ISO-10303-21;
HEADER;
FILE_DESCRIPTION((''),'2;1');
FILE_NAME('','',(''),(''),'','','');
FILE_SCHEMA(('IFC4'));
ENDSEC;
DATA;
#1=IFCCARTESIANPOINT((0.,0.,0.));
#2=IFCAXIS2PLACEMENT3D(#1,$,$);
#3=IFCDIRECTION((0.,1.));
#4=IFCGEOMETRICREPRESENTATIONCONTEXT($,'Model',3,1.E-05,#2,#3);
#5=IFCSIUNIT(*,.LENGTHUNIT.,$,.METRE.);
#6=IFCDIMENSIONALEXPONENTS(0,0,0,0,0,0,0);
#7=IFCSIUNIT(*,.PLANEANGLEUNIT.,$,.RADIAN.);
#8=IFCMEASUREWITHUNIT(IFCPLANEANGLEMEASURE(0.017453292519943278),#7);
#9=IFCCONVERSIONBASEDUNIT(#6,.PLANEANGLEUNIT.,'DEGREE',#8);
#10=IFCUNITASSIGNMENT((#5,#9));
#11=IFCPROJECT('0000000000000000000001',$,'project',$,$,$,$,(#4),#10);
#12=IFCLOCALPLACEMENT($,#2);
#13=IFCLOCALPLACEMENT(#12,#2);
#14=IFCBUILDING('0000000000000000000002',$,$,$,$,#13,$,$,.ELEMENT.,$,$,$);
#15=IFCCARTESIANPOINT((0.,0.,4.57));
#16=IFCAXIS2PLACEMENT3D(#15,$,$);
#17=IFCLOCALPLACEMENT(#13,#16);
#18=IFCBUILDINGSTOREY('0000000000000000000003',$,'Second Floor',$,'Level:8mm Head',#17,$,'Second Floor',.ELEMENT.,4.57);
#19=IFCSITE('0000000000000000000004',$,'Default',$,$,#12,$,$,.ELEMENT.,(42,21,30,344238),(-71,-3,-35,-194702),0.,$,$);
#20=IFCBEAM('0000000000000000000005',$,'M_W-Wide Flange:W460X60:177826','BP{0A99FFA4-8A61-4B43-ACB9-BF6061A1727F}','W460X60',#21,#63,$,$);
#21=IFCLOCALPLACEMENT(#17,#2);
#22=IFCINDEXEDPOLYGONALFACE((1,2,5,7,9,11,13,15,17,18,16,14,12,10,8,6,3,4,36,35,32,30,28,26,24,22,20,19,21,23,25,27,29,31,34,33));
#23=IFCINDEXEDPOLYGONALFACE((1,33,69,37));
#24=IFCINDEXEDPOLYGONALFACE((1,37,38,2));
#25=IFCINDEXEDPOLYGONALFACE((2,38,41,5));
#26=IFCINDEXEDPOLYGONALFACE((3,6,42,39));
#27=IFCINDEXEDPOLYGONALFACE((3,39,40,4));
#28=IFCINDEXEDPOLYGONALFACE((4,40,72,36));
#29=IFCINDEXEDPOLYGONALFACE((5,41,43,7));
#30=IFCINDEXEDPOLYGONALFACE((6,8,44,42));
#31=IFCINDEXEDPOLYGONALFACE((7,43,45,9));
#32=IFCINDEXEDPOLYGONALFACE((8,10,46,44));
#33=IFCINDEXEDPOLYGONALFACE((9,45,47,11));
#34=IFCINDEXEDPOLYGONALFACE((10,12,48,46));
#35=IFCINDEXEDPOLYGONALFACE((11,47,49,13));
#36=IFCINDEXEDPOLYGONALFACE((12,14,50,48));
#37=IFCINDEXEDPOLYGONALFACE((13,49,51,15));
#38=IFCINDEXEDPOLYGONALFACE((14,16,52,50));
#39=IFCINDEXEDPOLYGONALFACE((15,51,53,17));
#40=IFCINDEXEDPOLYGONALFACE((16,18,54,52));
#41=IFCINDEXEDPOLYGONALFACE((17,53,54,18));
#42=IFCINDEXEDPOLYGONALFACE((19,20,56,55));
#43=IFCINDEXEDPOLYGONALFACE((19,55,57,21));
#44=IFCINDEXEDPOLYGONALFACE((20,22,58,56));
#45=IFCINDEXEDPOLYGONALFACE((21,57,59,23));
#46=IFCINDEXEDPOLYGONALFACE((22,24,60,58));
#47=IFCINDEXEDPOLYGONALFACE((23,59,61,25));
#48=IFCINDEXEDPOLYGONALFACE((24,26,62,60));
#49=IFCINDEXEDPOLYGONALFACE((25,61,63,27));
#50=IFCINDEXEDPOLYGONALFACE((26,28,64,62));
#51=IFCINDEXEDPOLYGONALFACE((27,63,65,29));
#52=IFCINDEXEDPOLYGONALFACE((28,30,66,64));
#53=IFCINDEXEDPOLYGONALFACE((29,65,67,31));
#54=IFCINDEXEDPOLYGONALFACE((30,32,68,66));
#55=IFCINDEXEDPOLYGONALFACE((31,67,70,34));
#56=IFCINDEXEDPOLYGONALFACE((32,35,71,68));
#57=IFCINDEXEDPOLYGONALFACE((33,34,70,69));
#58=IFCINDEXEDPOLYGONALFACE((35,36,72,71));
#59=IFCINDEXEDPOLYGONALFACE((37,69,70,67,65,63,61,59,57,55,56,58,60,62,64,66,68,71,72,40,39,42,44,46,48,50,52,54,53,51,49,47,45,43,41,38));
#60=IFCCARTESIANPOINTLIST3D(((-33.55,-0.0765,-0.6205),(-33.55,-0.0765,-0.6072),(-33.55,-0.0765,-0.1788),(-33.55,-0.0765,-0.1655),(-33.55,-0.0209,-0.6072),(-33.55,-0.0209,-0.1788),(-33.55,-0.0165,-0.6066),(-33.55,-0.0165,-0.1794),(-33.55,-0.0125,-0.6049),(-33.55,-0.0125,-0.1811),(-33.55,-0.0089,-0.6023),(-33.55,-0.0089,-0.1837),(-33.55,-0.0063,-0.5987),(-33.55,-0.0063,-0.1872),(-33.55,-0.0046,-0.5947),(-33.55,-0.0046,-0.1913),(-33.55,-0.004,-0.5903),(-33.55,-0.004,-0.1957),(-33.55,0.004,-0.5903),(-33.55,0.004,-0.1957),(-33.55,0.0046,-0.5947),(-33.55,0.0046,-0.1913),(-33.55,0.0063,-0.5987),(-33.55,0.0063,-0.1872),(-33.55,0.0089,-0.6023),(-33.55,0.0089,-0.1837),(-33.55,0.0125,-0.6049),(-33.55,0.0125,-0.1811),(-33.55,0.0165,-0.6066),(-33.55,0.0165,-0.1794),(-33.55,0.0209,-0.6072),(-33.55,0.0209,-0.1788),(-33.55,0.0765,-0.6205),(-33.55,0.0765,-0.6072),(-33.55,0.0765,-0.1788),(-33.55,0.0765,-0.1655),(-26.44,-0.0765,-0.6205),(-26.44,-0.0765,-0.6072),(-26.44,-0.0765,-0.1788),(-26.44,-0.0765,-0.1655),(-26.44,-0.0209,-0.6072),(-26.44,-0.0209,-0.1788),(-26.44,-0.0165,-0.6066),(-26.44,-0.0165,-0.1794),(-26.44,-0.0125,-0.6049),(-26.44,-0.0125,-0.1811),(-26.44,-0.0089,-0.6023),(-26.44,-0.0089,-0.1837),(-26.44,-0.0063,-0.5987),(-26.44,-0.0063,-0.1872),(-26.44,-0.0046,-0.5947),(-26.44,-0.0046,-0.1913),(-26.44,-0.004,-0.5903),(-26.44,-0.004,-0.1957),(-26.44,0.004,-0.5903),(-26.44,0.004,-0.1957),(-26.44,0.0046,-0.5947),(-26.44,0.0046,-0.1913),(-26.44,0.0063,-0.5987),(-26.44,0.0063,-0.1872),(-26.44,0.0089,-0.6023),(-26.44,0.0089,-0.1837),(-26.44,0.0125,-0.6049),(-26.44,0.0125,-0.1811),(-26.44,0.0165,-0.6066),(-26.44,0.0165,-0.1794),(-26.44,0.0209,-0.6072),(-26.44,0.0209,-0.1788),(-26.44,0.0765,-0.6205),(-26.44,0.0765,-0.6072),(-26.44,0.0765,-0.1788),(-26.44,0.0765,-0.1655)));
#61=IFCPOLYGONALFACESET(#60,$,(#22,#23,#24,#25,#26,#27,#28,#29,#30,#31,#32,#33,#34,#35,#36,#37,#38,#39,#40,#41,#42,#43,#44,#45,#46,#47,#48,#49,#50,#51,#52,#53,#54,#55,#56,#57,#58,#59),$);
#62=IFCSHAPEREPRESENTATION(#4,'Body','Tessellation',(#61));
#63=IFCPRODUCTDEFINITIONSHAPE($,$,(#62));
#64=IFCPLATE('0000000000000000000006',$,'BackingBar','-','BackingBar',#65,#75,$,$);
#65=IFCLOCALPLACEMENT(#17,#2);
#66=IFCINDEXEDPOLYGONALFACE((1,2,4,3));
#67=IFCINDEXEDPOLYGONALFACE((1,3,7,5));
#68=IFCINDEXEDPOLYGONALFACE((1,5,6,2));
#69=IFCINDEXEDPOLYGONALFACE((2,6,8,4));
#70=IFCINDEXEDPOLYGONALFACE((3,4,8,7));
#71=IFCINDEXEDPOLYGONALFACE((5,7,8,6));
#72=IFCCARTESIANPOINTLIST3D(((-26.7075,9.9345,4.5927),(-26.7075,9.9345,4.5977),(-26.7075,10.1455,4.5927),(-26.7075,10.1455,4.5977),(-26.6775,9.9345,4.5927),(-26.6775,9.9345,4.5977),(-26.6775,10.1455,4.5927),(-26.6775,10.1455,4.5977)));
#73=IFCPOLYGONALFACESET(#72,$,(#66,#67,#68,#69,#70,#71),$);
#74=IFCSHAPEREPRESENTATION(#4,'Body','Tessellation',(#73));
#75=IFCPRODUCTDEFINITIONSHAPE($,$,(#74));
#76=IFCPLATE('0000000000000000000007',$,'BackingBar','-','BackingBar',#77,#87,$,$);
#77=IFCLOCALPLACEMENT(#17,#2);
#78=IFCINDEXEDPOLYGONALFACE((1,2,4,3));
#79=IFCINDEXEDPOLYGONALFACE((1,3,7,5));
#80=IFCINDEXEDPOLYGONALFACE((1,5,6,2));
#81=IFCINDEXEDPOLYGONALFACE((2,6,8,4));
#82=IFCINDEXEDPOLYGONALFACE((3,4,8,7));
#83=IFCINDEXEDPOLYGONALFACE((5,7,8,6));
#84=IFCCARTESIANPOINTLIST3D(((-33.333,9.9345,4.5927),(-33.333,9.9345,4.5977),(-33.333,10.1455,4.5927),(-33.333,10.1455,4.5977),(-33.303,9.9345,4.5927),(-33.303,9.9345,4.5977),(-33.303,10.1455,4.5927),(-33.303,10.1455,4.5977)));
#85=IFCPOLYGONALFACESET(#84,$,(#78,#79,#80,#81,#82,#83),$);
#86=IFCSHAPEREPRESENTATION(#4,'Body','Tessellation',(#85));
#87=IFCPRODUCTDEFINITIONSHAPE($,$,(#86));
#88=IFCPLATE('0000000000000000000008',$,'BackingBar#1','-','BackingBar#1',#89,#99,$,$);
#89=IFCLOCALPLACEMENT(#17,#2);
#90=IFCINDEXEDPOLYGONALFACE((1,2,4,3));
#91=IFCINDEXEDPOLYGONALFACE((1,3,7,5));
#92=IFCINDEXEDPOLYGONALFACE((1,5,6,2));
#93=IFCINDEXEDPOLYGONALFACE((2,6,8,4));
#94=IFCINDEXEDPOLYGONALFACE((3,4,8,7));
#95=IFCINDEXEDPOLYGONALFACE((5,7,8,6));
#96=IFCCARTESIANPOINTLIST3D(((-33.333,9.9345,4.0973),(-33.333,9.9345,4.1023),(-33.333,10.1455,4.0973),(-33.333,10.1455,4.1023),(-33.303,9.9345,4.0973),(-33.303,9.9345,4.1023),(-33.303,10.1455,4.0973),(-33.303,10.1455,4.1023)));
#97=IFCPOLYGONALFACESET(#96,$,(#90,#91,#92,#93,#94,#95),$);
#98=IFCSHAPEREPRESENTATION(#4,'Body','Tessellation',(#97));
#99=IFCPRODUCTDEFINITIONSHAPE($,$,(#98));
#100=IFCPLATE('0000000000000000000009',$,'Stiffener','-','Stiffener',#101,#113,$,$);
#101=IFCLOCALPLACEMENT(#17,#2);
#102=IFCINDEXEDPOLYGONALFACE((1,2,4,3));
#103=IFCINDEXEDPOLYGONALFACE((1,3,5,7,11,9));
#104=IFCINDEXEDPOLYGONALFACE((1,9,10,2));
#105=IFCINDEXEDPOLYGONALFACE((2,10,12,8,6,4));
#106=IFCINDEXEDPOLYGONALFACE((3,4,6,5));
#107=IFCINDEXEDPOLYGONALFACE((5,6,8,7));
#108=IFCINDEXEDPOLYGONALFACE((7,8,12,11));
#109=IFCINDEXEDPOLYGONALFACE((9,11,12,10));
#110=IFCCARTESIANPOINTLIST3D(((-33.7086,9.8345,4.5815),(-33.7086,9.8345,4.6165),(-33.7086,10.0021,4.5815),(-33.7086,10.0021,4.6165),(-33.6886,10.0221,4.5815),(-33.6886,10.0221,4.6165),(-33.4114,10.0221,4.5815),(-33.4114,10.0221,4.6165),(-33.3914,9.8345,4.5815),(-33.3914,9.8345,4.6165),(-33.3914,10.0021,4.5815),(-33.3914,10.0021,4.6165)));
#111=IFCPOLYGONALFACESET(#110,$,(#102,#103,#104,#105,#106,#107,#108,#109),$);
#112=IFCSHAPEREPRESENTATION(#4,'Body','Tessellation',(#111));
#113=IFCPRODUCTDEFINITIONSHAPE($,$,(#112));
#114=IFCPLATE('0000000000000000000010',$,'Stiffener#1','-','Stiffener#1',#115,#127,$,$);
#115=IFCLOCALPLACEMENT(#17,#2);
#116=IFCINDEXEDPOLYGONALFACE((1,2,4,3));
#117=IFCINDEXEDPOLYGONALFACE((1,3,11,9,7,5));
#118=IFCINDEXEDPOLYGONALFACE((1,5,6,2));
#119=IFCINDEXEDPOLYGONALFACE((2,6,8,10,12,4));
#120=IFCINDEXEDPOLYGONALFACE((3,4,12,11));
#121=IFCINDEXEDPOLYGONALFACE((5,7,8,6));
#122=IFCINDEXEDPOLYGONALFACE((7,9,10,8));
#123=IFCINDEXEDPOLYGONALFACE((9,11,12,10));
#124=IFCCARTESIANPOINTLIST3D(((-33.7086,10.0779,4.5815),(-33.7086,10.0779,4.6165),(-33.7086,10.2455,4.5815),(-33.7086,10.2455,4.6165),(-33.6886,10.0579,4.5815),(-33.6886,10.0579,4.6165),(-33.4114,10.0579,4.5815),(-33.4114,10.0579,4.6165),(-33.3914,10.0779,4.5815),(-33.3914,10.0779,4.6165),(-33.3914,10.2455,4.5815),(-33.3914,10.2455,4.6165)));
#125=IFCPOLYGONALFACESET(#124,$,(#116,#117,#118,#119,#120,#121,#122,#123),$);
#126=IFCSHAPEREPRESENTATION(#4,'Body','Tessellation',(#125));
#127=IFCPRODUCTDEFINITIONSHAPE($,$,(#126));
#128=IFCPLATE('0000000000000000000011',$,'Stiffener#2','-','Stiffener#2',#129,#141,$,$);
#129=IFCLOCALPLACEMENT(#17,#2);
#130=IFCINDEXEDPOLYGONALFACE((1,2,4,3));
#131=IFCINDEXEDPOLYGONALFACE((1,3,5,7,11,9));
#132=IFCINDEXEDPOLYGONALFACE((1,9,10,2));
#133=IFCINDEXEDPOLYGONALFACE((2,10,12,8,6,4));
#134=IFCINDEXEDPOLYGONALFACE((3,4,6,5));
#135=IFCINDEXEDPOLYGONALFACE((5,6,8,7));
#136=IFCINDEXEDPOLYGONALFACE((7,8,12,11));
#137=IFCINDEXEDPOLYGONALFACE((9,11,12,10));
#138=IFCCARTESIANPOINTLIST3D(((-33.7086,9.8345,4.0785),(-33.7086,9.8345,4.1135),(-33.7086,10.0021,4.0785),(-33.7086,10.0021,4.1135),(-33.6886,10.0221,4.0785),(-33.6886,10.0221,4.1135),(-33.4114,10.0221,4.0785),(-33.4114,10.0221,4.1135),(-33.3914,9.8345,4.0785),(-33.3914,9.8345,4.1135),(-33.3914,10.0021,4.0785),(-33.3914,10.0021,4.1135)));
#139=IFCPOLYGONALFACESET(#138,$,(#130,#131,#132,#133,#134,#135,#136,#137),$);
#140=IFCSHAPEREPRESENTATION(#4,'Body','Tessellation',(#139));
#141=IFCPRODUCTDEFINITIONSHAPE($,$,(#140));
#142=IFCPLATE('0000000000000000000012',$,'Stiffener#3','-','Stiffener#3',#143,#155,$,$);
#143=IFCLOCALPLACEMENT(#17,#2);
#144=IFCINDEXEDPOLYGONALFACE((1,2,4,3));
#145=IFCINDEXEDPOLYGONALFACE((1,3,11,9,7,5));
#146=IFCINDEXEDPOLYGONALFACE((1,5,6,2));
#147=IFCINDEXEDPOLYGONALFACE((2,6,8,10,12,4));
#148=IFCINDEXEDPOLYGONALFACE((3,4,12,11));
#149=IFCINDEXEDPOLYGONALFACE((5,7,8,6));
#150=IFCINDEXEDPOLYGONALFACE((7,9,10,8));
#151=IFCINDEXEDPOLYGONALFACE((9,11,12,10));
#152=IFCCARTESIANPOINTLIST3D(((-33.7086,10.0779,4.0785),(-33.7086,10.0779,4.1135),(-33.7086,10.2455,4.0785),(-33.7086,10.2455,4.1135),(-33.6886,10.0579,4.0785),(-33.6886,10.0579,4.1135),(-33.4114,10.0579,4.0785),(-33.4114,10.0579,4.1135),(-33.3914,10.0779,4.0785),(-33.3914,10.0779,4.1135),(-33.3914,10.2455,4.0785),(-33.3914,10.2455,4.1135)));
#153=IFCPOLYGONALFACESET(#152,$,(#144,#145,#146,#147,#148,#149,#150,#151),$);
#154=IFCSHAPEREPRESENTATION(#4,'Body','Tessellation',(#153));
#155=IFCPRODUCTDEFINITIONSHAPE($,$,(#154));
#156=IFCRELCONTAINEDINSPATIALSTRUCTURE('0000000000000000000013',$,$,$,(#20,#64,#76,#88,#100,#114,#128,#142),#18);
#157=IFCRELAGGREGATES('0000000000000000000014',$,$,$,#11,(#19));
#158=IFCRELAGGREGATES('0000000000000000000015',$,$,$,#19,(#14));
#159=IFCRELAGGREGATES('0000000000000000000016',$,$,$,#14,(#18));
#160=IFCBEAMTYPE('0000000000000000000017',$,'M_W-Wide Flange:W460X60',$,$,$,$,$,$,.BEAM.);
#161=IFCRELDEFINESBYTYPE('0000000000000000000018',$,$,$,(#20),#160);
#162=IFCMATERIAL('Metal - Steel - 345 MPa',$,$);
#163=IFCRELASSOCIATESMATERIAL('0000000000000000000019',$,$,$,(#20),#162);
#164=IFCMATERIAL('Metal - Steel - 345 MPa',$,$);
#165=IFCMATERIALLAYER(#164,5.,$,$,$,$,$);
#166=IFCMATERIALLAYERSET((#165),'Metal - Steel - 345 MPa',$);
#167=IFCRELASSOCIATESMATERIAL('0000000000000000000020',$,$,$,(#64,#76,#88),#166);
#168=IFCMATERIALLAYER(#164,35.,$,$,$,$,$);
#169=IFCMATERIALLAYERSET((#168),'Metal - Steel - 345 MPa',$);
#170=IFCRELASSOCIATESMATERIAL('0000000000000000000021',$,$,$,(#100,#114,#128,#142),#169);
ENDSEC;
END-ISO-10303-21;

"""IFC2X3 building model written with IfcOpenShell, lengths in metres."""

from ifc_helpers import new_model, entity, si_unit, converted_unit, direction, frame, origin, origin_with_axes, origin_2d, place, context, project, spatial, polyline, i_section, outline, extrude, material, layer, layer_set, type_object, element, save


model = new_model("IFC2X3")

# Units and contexts
model_context = context("Model", 3, precision=1e-05, world=origin(), true_north=direction((0.0, 1.0)))
ifc_project = project(units=[si_unit("LENGTHUNIT", "METRE"), converted_unit("PLANEANGLEUNIT", "DEGREE", entity("IfcPlaneAngleMeasure", 0.017453292519943278), si_unit("PLANEANGLEUNIT", "RADIAN"), dimensions=[0, 0, 0, 0, 0, 0, 0])], contexts=[model_context])

# Site, building, storey
site_placement = place(None, origin())
site = spatial("IfcSite", under=ifc_project, at=site_placement, Name="Default", CompositionType="ELEMENT", RefLatitude=(42, 21, 30, 344238), RefLongitude=(-71, -3, -35, -194702), RefElevation=0.0)
building_placement = place(site_placement, origin())
building = spatial("IfcBuilding", under=site, at=building_placement, CompositionType="ELEMENT")
storey_placement = place(building_placement, frame((0.0, 0.0, 4.57)))
storey = spatial("IfcBuildingStorey", under=building, at=storey_placement, Name="Second Floor", ObjectType="Level:8mm Head", LongName="Second Floor", CompositionType="ELEMENT", Elevation=4.57)

# Beam
ifc_material_1 = material(Name="Metal - Steel - 345 MPa")
beam_type_1 = type_object("IfcBeamType", Name="M_W-Wide Flange:W460X60", PredefinedType="BEAM")
beam_1_placement = place(storey_placement, frame((-33.55, 0.0, -0.393), z_axis=(-1.0, 0.0, 0.0), x_axis=(0.0, -1.0, 0.0)))
element("IfcBeam", 1, at=beam_1_placement, inside=storey, type_object=beam_type_1, material=ifc_material_1, Name="M_W-Wide Flange:W460X60:177826", Description="BP{0A99FFA4-8A61-4B43-ACB9-BF6061A1727F}", ObjectType="W460X60", context=model_context, shape_type="SweptSolid", body=[
    extrude(i_section(OverallWidth=0.153, OverallDepth=0.455, WebThickness=0.008, FlangeThickness=0.0133, FilletRadius=0.0169, at=origin_2d()), origin(), (0.0, 0.0, -1.0), 7.11),
])

# Plates
ifc_material_2 = material(Name="Metal - Steel - 345 MPa")
ifc_layer_1 = layer(ifc_material_2, 5.0)
ifc_layer_set_1 = layer_set([ifc_layer_1], Name="Metal - Steel - 345 MPa")
for number, where, z_axis, x_axis, name in (
    (2, (-26.6775, 9.9345, 4.5927), (0.0, 0.0, 1.0), (0.0, 1.0, 0.0), "BackingBar"),
    (3, (-33.333, 10.1455, 4.5927), (0.0, 0.0, 1.0), (0.0, -1.0, 0.0), "BackingBar"),
):
    element("IfcPlate", number, at=place(storey_placement, frame(where, z_axis=z_axis, x_axis=x_axis)), inside=storey, material=ifc_layer_set_1, Name=name, Description="-", ObjectType="BackingBar", context=model_context, shape_type="SweptSolid", body=[
        extrude(outline(polyline([(0.0, 0.0), (0.211, 0.0), (0.211, 0.03), (0.0, 0.03), (0.0, 0.0)])), origin_with_axes(), (0.0, 0.0, 1.0), 0.005),
    ])
plate_1_placement = place(storey_placement, frame((-33.333, 9.9345, 4.1023), z_axis=(0.0, 0.0, -1.0), x_axis=(0.0, 1.0, 0.0)))
element("IfcPlate", 4, at=plate_1_placement, inside=storey, material=ifc_layer_set_1, Name="BackingBar#1", Description="-", ObjectType="BackingBar#1", context=model_context, shape_type="SweptSolid", body=[
    extrude(outline(polyline([(0.0, 0.0), (0.211, 0.0), (0.211, 0.03), (0.0, 0.03), (0.0, 0.0)])), origin_with_axes(), (0.0, 0.0, 1.0), 0.005),
])

# Plates, openings
ifc_layer_2 = layer(ifc_material_2, 35.0)
ifc_layer_set_2 = layer_set([ifc_layer_2], Name="Metal - Steel - 345 MPa")
plate_2_placement = place(storey_placement, frame((-33.3914, 9.8345, 4.5815), z_axis=(0.0, 0.0, 1.0), x_axis=(0.0, 1.0, 0.0)))
plate_2 = element("IfcPlate", 5, at=plate_2_placement, inside=storey, material=ifc_layer_set_2, Name="Stiffener", Description="-", ObjectType="Stiffener", context=model_context, shape_type="SweptSolid", body=[
    extrude(outline(polyline([(0.0, 0.0), (0.1876, 0.0), (0.1876, 0.3172), (0.0, 0.3172), (0.0, 0.0)])), origin_with_axes(), (0.0, 0.0, 1.0), 0.035),
])
opening_1_placement = place(plate_2_placement, frame((0.0, 0.0, 0.0), z_axis=(0.0, 0.0, 1.0), x_axis=(1.0, 0.0, 0.0)))
element("IfcOpeningElement", 6, at=opening_1_placement, cuts=plate_2, ObjectType="Opening", context=model_context, shape_type="SweptSolid", body=[
    extrude(outline(polyline([(0.1876, 0.3172), (0.1676, 0.3172), (0.1876, 0.2972), (0.1876, 0.3172)])), origin(), (0.0, 0.0, 1.0), 0.035),
])
opening_2_placement = place(plate_2_placement, frame((0.0, 0.0, 0.0), z_axis=(0.0, 0.0, 1.0), x_axis=(1.0, 0.0, 0.0)))
element("IfcOpeningElement", 7, at=opening_2_placement, cuts=plate_2, ObjectType="Opening", context=model_context, shape_type="SweptSolid", body=[
    extrude(outline(polyline([(0.1876, 0.0), (0.1876, 0.02), (0.1676, 0.0), (0.1876, 0.0)])), origin(), (0.0, 0.0, 1.0), 0.035),
])
plate_3_placement = place(storey_placement, frame((-33.3914, 10.0579, 4.5815), z_axis=(0.0, 0.0, 1.0), x_axis=(0.0, 1.0, 0.0)))
plate_3 = element("IfcPlate", 8, at=plate_3_placement, inside=storey, material=ifc_layer_set_2, Name="Stiffener#1", Description="-", ObjectType="Stiffener#1", context=model_context, shape_type="SweptSolid", body=[
    extrude(outline(polyline([(0.0, 0.0), (0.1876, 0.0), (0.1876, 0.3172), (0.0, 0.3172), (0.0, 0.0)])), origin_with_axes(), (0.0, 0.0, 1.0), 0.035),
])
opening_3_placement = place(plate_3_placement, frame((0.0, 0.0, 0.0), z_axis=(0.0, 0.0, 1.0), x_axis=(1.0, 0.0, 0.0)))
element("IfcOpeningElement", 9, at=opening_3_placement, cuts=plate_3, ObjectType="Opening", context=model_context, shape_type="SweptSolid", body=[
    extrude(outline(polyline([(0.0, 0.3172), (0.0, 0.2972), (0.02, 0.3172), (0.0, 0.3172)])), origin(), (0.0, 0.0, 1.0), 0.035),
])
opening_4_placement = place(plate_3_placement, frame((0.0, 0.0, 0.0), z_axis=(0.0, 0.0, 1.0), x_axis=(1.0, 0.0, 0.0)))
element("IfcOpeningElement", 10, at=opening_4_placement, cuts=plate_3, ObjectType="Opening", context=model_context, shape_type="SweptSolid", body=[
    extrude(outline(polyline([(0.0, 0.0), (0.02, 0.0), (0.0, 0.02), (0.0, 0.0)])), origin(), (0.0, 0.0, 1.0), 0.035),
])
plate_4_placement = place(storey_placement, frame((-33.3914, 10.0221, 4.1135), z_axis=(0.0, 0.0, -1.0), x_axis=(0.0, -1.0, 0.0)))
plate_4 = element("IfcPlate", 11, at=plate_4_placement, inside=storey, material=ifc_layer_set_2, Name="Stiffener#2", Description="-", ObjectType="Stiffener#2", context=model_context, shape_type="SweptSolid", body=[
    extrude(outline(polyline([(0.0, 0.0), (0.1876, 0.0), (0.1876, 0.3172), (0.0, 0.3172), (0.0, 0.0)])), origin_with_axes(), (0.0, 0.0, 1.0), 0.035),
])
opening_5_placement = place(plate_4_placement, frame((0.0, 0.0, 0.0), z_axis=(0.0, 0.0, 1.0), x_axis=(1.0, 0.0, 0.0)))
element("IfcOpeningElement", 12, at=opening_5_placement, cuts=plate_4, ObjectType="Opening", context=model_context, shape_type="SweptSolid", body=[
    extrude(outline(polyline([(0.0, 0.3172), (0.0, 0.2972), (0.02, 0.3172), (0.0, 0.3172)])), origin(), (0.0, 0.0, 1.0), 0.035),
])
opening_6_placement = place(plate_4_placement, frame((0.0, 0.0, 0.0), z_axis=(0.0, 0.0, 1.0), x_axis=(1.0, 0.0, 0.0)))
element("IfcOpeningElement", 13, at=opening_6_placement, cuts=plate_4, ObjectType="Opening", context=model_context, shape_type="SweptSolid", body=[
    extrude(outline(polyline([(0.0, 0.0), (0.02, 0.0), (0.0, 0.02), (0.0, 0.0)])), origin(), (0.0, 0.0, 1.0), 0.035),
])
plate_5_placement = place(storey_placement, frame((-33.3914, 10.2455, 4.1135), z_axis=(0.0, 0.0, -1.0), x_axis=(0.0, -1.0, 0.0)))
plate_5 = element("IfcPlate", 14, at=plate_5_placement, inside=storey, material=ifc_layer_set_2, Name="Stiffener#3", Description="-", ObjectType="Stiffener#3", context=model_context, shape_type="SweptSolid", body=[
    extrude(outline(polyline([(0.0, 0.0), (0.1876, 0.0), (0.1876, 0.3172), (0.0, 0.3172), (0.0, 0.0)])), origin_with_axes(), (0.0, 0.0, 1.0), 0.035),
])
opening_7_placement = place(plate_5_placement, frame((0.0, 0.0, 0.0), z_axis=(0.0, 0.0, 1.0), x_axis=(1.0, 0.0, 0.0)))
element("IfcOpeningElement", 15, at=opening_7_placement, cuts=plate_5, ObjectType="Opening", context=model_context, shape_type="SweptSolid", body=[
    extrude(outline(polyline([(0.1876, 0.3172), (0.1676, 0.3172), (0.1876, 0.2972), (0.1876, 0.3172)])), origin(), (0.0, 0.0, 1.0), 0.035),
])
opening_8_placement = place(plate_5_placement, frame((0.0, 0.0, 0.0), z_axis=(0.0, 0.0, 1.0), x_axis=(1.0, 0.0, 0.0)))
element("IfcOpeningElement", 16, at=opening_8_placement, cuts=plate_5, ObjectType="Opening", context=model_context, shape_type="SweptSolid", body=[
    extrude(outline(polyline([(0.1876, 0.0), (0.1876, 0.02), (0.1676, 0.0), (0.1876, 0.0)])), origin(), (0.0, 0.0, 1.0), 0.035),
])

save(model, "model.ifc")
